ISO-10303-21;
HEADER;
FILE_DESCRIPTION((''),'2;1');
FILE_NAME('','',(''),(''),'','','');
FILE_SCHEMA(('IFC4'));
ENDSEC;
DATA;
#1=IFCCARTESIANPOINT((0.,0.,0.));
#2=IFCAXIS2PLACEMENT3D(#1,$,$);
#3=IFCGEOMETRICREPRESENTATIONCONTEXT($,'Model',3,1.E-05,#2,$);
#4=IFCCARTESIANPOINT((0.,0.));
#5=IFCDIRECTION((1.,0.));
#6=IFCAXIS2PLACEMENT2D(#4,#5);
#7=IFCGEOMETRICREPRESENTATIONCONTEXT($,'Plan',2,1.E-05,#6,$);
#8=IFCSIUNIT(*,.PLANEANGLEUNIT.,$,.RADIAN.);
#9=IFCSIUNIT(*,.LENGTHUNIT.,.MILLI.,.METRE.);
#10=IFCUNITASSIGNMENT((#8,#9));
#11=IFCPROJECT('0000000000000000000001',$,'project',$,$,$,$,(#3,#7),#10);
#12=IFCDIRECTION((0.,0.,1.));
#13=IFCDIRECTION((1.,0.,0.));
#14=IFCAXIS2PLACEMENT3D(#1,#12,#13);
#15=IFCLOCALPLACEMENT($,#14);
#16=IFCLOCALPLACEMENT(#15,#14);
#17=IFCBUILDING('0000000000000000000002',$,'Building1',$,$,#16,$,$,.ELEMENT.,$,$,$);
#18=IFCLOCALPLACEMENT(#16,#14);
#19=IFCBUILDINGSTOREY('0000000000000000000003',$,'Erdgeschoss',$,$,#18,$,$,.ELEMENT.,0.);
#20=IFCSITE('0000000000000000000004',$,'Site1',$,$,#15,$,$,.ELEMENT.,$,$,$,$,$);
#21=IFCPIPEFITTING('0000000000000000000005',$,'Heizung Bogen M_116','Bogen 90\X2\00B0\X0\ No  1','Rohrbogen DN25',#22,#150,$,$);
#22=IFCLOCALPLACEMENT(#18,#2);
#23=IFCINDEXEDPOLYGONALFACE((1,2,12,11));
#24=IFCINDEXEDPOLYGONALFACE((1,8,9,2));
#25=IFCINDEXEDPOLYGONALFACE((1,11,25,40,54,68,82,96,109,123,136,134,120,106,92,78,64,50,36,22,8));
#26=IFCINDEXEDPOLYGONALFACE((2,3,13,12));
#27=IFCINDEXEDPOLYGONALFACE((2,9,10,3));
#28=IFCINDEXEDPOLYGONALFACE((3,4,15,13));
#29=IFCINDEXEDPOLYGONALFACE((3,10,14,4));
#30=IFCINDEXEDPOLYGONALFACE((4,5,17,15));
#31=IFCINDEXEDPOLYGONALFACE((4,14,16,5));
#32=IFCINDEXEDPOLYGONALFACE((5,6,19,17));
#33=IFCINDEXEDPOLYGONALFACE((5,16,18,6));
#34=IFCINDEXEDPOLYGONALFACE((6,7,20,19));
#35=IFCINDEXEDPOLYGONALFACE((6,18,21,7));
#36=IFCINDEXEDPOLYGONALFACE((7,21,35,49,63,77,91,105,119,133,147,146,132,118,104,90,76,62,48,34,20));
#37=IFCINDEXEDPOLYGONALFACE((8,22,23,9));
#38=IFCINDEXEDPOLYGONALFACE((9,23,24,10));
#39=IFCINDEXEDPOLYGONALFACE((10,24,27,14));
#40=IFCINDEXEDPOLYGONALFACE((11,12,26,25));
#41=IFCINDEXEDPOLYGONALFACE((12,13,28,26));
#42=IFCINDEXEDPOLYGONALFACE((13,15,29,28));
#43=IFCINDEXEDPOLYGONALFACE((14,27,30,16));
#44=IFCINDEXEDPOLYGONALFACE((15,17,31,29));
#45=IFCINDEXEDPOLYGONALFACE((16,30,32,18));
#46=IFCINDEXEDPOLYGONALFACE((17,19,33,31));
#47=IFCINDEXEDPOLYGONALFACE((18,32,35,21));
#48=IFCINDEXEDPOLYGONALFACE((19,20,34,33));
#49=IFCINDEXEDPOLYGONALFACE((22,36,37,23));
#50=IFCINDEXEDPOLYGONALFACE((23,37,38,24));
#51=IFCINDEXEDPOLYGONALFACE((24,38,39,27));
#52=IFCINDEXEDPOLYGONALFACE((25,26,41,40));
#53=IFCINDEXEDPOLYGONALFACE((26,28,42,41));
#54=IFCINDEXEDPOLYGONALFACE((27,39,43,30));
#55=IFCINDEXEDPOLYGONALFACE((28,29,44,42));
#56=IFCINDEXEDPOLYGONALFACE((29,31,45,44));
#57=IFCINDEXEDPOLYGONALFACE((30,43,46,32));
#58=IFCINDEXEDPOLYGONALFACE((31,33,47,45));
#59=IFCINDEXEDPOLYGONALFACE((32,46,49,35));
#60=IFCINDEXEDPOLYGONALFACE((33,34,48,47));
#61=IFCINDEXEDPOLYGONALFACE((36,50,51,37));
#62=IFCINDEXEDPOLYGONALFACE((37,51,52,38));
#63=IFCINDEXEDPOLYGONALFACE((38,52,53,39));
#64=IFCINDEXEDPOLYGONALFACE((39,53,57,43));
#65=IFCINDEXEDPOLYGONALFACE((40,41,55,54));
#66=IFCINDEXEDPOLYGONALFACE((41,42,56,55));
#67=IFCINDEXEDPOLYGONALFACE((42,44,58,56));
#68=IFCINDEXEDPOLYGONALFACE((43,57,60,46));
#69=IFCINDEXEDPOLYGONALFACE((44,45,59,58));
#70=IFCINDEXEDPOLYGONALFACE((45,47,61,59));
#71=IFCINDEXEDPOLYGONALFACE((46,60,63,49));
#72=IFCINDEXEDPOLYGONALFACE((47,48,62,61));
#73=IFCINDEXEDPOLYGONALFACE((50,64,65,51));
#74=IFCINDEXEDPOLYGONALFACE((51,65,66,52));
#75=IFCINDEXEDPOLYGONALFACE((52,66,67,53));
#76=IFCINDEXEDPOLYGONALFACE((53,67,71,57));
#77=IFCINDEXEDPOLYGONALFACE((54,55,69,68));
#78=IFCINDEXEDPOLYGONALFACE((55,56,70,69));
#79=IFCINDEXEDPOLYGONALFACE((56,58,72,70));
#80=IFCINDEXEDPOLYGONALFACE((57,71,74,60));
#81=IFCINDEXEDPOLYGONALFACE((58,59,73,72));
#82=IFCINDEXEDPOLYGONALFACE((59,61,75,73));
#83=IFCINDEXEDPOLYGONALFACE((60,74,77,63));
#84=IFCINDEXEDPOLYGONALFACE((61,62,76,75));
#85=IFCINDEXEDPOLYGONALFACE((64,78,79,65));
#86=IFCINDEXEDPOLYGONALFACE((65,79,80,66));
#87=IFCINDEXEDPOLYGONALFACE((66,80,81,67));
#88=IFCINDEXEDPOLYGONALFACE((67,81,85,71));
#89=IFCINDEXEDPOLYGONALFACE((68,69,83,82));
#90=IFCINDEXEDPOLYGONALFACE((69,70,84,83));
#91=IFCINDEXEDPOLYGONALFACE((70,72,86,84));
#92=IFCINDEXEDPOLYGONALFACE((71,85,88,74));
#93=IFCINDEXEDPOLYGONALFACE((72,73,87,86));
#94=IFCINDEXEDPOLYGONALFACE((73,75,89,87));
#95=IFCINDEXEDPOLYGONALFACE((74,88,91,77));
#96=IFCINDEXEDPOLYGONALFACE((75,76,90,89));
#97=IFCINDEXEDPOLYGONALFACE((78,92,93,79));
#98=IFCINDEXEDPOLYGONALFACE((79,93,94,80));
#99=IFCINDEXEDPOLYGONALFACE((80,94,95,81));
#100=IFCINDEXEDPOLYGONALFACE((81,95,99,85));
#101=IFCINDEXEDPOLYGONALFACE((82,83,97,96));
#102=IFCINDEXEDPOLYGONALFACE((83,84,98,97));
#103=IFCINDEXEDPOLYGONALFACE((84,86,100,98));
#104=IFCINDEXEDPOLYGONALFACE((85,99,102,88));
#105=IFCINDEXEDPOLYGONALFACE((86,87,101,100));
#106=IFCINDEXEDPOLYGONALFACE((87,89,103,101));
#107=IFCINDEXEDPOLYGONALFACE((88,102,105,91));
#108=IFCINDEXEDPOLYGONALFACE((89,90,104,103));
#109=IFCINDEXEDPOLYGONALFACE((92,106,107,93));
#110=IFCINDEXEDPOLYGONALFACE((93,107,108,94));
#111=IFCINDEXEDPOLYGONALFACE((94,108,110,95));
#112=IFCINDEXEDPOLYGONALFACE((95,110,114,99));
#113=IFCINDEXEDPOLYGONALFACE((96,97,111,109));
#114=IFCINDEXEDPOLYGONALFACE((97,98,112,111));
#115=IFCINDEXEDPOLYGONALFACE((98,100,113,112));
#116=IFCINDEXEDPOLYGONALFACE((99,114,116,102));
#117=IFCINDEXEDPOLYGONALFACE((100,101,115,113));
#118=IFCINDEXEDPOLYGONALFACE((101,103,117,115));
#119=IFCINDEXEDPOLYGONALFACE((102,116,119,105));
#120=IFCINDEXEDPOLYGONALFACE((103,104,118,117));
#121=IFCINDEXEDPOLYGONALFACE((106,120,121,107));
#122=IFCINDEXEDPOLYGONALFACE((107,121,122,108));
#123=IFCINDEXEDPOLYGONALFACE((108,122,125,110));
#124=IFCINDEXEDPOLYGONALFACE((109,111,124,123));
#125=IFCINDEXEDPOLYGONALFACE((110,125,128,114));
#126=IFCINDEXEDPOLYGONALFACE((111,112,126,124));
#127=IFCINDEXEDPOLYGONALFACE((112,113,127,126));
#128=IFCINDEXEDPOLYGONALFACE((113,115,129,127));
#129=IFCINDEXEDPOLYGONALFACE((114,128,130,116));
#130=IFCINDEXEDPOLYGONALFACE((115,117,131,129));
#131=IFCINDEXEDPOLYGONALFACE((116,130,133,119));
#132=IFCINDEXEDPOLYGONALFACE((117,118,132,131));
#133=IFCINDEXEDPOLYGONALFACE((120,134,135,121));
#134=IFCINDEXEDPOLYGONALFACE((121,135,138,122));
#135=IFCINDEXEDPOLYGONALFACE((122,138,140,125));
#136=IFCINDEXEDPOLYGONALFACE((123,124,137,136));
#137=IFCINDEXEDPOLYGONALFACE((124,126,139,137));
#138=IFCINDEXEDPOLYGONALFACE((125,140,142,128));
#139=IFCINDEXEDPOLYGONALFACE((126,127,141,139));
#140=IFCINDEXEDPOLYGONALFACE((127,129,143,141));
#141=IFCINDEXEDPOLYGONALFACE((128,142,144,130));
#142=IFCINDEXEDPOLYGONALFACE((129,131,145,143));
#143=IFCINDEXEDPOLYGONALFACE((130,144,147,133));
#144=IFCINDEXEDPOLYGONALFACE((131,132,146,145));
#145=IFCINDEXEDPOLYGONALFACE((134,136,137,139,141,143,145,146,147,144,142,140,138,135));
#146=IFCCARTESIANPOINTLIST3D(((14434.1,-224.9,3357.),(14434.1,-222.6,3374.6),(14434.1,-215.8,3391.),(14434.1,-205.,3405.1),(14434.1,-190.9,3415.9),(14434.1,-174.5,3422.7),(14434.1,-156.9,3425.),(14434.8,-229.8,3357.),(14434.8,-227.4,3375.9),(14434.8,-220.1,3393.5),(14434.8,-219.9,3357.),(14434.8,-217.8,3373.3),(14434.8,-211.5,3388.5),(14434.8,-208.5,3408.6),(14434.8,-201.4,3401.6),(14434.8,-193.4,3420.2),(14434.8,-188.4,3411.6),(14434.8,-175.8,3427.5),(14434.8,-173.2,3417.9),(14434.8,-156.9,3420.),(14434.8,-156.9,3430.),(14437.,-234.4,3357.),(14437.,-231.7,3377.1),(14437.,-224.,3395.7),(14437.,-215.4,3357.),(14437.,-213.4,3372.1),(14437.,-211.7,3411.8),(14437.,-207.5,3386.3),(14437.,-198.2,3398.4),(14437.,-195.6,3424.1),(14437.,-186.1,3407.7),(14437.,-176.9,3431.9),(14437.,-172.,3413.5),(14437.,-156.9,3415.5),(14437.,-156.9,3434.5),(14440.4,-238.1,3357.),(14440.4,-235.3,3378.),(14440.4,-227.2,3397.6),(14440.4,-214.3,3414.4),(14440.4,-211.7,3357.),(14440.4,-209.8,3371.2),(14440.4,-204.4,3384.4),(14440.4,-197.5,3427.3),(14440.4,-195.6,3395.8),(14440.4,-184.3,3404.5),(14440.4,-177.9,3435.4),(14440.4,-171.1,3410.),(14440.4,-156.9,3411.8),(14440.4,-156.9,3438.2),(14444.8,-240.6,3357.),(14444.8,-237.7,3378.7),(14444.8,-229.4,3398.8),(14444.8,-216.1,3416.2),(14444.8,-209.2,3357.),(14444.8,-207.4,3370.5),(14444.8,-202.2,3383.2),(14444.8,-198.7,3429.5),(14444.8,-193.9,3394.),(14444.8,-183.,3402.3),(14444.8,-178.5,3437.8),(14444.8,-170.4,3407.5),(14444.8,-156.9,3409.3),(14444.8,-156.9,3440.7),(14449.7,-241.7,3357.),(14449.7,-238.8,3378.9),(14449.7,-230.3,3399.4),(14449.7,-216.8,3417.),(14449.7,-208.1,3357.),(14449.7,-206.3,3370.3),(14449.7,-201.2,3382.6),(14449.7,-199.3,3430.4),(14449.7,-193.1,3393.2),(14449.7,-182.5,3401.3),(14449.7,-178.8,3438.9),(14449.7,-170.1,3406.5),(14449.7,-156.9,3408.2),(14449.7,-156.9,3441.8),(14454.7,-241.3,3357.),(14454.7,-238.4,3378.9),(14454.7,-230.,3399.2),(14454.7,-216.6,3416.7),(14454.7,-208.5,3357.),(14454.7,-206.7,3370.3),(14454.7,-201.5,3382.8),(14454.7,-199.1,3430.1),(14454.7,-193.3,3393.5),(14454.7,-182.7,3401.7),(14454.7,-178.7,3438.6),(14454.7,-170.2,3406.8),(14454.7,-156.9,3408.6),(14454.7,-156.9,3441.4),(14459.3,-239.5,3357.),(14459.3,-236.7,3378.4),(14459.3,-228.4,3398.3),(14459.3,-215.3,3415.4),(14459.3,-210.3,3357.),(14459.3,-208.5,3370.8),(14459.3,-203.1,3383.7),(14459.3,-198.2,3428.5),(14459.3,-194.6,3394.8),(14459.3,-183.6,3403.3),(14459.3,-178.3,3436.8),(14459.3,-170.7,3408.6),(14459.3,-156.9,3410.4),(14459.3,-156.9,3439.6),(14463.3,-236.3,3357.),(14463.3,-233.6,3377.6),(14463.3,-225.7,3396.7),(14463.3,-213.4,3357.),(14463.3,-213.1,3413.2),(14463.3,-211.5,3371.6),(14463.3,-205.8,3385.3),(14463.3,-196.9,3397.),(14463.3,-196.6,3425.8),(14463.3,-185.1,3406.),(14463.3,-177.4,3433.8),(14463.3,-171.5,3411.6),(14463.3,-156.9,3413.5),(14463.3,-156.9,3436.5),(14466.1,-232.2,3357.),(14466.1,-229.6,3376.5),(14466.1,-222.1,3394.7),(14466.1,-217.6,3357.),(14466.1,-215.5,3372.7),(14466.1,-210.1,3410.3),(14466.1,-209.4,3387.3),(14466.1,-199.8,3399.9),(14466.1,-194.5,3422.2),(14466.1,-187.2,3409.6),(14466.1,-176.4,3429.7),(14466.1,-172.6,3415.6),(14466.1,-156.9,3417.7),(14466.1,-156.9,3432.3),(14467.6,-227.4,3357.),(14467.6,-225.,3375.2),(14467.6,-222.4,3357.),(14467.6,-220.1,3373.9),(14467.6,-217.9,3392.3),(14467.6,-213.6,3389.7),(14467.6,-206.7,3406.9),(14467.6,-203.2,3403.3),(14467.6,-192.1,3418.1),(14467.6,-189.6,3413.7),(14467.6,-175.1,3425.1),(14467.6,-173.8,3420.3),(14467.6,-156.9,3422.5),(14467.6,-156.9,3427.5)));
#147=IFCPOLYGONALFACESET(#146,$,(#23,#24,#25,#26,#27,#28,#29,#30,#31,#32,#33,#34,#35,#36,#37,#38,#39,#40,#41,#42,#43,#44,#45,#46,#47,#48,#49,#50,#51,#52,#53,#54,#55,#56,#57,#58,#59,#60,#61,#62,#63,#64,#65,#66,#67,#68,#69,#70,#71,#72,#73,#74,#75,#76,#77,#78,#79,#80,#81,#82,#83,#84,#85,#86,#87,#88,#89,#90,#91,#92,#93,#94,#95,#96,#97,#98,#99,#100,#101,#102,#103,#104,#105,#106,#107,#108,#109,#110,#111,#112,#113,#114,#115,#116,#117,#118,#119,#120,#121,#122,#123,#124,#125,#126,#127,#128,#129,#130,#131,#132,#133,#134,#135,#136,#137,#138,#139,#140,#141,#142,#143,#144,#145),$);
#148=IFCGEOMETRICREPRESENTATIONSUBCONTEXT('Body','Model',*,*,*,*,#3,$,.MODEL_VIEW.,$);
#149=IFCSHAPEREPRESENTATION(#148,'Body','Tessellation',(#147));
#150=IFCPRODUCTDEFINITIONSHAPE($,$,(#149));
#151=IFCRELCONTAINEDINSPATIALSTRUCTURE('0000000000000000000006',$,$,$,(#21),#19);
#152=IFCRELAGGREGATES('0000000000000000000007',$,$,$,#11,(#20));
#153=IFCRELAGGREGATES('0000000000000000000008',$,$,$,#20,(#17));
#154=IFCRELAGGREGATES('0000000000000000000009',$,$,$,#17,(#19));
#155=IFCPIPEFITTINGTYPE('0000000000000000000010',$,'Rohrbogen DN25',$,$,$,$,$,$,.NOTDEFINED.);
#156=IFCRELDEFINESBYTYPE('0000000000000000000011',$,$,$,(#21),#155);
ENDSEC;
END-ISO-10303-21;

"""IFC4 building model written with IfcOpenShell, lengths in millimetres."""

from ifc_helpers import new_model, entity, si_unit, frame, origin, origin_with_axes, origin_2d_with_axis, place, context, subcontext, project, spatial, shape, source, transform, mapped, type_object, element, save


model = new_model("IFC4")

# Units and contexts
model_context = context("Model", 3, precision=1e-05, world=origin())
plan_context = context("Plan", 2, precision=1e-05, world=origin_2d_with_axis())
body_context = subcontext(model_context, "Body", "Model", "MODEL_VIEW")
ifc_project = project(units=[si_unit("PLANEANGLEUNIT", "RADIAN"), si_unit("LENGTHUNIT", "METRE", prefix="MILLI")], contexts=[model_context, plan_context])

# Site, building, storey
site_placement = place(None, origin_with_axes())
site = spatial("IfcSite", under=ifc_project, at=site_placement, Name="Site1", CompositionType="ELEMENT")
building_placement = place(site_placement, origin_with_axes())
building = spatial("IfcBuilding", under=site, at=building_placement, Name="Building1", CompositionType="ELEMENT")
storey_placement = place(building_placement, origin_with_axes())
storey = spatial("IfcBuildingStorey", under=building, at=storey_placement, Name="Erdgeschoss", CompositionType="ELEMENT", Elevation=0.0)

# Pipe fitting
pipe_fitting_type = type_object("IfcPipeFittingType", Name="Rohrbogen DN25", PredefinedType="NOTDEFINED")
shared_shape_1 = source(origin_with_axes(), body_context, "Body", "SolidModel", [
    entity("IfcRevolvedAreaSolid", entity("IfcCircleProfileDef", "AREA", None, entity("IfcAxis2Placement2D", entity("IfcCartesianPoint", [0.0, 0.0]), entity("IfcDirection", [1.0, 0.0])), 16.9), entity("IfcAxis2Placement3D", entity("IfcCartesianPoint", [-42.4, 0.0, 25.6]), entity("IfcDirection", [1.0, 0.0, 0.0]), entity("IfcDirection", [0.0, -1.0, 0.0])), entity("IfcAxis1Placement", entity("IfcCartesianPoint", [0.0, 68.0, 0.0]), entity("IfcDirection", [-1.0, 0.0, 0.0])), 1.570796),
])
for number, where, z_axis, x_axis, name in (
    (1, (14450.9, -199.3, 3399.4), (0.0, 0.0, 1.0), (1.0, 0.0, 0.0), "Heizung Bogen M_116"),
):
    element("IfcPipeFitting", number, at=place(storey_placement, frame(where, z_axis=z_axis, x_axis=x_axis)), inside=storey, type_object=pipe_fitting_type, Name=name, Description="Bogen 90° No  1", ObjectType="Rohrbogen DN25", shapes=[
        shape(body_context, "Body", "MappedRepresentation", [mapped(shared_shape_1, transform((0.0, 0.0, 0.0), x_axis=(0.0, -1.0, 0.0), y_axis=(1.0, 0.0, 0.0), z_axis=(0.0, 0.0, 1.0), scale=1.0))]),
        shape(body_context, "Body", "MappedRepresentation", [mapped(shared_shape_1, transform((0.0, 0.0, 0.0), x_axis=(0.0, -1.0, 0.0), y_axis=(1.0, 0.0, 0.0), z_axis=(0.0, 0.0, 1.0), scale=1.0))]),
    ])

save(model, "model.ifc")
